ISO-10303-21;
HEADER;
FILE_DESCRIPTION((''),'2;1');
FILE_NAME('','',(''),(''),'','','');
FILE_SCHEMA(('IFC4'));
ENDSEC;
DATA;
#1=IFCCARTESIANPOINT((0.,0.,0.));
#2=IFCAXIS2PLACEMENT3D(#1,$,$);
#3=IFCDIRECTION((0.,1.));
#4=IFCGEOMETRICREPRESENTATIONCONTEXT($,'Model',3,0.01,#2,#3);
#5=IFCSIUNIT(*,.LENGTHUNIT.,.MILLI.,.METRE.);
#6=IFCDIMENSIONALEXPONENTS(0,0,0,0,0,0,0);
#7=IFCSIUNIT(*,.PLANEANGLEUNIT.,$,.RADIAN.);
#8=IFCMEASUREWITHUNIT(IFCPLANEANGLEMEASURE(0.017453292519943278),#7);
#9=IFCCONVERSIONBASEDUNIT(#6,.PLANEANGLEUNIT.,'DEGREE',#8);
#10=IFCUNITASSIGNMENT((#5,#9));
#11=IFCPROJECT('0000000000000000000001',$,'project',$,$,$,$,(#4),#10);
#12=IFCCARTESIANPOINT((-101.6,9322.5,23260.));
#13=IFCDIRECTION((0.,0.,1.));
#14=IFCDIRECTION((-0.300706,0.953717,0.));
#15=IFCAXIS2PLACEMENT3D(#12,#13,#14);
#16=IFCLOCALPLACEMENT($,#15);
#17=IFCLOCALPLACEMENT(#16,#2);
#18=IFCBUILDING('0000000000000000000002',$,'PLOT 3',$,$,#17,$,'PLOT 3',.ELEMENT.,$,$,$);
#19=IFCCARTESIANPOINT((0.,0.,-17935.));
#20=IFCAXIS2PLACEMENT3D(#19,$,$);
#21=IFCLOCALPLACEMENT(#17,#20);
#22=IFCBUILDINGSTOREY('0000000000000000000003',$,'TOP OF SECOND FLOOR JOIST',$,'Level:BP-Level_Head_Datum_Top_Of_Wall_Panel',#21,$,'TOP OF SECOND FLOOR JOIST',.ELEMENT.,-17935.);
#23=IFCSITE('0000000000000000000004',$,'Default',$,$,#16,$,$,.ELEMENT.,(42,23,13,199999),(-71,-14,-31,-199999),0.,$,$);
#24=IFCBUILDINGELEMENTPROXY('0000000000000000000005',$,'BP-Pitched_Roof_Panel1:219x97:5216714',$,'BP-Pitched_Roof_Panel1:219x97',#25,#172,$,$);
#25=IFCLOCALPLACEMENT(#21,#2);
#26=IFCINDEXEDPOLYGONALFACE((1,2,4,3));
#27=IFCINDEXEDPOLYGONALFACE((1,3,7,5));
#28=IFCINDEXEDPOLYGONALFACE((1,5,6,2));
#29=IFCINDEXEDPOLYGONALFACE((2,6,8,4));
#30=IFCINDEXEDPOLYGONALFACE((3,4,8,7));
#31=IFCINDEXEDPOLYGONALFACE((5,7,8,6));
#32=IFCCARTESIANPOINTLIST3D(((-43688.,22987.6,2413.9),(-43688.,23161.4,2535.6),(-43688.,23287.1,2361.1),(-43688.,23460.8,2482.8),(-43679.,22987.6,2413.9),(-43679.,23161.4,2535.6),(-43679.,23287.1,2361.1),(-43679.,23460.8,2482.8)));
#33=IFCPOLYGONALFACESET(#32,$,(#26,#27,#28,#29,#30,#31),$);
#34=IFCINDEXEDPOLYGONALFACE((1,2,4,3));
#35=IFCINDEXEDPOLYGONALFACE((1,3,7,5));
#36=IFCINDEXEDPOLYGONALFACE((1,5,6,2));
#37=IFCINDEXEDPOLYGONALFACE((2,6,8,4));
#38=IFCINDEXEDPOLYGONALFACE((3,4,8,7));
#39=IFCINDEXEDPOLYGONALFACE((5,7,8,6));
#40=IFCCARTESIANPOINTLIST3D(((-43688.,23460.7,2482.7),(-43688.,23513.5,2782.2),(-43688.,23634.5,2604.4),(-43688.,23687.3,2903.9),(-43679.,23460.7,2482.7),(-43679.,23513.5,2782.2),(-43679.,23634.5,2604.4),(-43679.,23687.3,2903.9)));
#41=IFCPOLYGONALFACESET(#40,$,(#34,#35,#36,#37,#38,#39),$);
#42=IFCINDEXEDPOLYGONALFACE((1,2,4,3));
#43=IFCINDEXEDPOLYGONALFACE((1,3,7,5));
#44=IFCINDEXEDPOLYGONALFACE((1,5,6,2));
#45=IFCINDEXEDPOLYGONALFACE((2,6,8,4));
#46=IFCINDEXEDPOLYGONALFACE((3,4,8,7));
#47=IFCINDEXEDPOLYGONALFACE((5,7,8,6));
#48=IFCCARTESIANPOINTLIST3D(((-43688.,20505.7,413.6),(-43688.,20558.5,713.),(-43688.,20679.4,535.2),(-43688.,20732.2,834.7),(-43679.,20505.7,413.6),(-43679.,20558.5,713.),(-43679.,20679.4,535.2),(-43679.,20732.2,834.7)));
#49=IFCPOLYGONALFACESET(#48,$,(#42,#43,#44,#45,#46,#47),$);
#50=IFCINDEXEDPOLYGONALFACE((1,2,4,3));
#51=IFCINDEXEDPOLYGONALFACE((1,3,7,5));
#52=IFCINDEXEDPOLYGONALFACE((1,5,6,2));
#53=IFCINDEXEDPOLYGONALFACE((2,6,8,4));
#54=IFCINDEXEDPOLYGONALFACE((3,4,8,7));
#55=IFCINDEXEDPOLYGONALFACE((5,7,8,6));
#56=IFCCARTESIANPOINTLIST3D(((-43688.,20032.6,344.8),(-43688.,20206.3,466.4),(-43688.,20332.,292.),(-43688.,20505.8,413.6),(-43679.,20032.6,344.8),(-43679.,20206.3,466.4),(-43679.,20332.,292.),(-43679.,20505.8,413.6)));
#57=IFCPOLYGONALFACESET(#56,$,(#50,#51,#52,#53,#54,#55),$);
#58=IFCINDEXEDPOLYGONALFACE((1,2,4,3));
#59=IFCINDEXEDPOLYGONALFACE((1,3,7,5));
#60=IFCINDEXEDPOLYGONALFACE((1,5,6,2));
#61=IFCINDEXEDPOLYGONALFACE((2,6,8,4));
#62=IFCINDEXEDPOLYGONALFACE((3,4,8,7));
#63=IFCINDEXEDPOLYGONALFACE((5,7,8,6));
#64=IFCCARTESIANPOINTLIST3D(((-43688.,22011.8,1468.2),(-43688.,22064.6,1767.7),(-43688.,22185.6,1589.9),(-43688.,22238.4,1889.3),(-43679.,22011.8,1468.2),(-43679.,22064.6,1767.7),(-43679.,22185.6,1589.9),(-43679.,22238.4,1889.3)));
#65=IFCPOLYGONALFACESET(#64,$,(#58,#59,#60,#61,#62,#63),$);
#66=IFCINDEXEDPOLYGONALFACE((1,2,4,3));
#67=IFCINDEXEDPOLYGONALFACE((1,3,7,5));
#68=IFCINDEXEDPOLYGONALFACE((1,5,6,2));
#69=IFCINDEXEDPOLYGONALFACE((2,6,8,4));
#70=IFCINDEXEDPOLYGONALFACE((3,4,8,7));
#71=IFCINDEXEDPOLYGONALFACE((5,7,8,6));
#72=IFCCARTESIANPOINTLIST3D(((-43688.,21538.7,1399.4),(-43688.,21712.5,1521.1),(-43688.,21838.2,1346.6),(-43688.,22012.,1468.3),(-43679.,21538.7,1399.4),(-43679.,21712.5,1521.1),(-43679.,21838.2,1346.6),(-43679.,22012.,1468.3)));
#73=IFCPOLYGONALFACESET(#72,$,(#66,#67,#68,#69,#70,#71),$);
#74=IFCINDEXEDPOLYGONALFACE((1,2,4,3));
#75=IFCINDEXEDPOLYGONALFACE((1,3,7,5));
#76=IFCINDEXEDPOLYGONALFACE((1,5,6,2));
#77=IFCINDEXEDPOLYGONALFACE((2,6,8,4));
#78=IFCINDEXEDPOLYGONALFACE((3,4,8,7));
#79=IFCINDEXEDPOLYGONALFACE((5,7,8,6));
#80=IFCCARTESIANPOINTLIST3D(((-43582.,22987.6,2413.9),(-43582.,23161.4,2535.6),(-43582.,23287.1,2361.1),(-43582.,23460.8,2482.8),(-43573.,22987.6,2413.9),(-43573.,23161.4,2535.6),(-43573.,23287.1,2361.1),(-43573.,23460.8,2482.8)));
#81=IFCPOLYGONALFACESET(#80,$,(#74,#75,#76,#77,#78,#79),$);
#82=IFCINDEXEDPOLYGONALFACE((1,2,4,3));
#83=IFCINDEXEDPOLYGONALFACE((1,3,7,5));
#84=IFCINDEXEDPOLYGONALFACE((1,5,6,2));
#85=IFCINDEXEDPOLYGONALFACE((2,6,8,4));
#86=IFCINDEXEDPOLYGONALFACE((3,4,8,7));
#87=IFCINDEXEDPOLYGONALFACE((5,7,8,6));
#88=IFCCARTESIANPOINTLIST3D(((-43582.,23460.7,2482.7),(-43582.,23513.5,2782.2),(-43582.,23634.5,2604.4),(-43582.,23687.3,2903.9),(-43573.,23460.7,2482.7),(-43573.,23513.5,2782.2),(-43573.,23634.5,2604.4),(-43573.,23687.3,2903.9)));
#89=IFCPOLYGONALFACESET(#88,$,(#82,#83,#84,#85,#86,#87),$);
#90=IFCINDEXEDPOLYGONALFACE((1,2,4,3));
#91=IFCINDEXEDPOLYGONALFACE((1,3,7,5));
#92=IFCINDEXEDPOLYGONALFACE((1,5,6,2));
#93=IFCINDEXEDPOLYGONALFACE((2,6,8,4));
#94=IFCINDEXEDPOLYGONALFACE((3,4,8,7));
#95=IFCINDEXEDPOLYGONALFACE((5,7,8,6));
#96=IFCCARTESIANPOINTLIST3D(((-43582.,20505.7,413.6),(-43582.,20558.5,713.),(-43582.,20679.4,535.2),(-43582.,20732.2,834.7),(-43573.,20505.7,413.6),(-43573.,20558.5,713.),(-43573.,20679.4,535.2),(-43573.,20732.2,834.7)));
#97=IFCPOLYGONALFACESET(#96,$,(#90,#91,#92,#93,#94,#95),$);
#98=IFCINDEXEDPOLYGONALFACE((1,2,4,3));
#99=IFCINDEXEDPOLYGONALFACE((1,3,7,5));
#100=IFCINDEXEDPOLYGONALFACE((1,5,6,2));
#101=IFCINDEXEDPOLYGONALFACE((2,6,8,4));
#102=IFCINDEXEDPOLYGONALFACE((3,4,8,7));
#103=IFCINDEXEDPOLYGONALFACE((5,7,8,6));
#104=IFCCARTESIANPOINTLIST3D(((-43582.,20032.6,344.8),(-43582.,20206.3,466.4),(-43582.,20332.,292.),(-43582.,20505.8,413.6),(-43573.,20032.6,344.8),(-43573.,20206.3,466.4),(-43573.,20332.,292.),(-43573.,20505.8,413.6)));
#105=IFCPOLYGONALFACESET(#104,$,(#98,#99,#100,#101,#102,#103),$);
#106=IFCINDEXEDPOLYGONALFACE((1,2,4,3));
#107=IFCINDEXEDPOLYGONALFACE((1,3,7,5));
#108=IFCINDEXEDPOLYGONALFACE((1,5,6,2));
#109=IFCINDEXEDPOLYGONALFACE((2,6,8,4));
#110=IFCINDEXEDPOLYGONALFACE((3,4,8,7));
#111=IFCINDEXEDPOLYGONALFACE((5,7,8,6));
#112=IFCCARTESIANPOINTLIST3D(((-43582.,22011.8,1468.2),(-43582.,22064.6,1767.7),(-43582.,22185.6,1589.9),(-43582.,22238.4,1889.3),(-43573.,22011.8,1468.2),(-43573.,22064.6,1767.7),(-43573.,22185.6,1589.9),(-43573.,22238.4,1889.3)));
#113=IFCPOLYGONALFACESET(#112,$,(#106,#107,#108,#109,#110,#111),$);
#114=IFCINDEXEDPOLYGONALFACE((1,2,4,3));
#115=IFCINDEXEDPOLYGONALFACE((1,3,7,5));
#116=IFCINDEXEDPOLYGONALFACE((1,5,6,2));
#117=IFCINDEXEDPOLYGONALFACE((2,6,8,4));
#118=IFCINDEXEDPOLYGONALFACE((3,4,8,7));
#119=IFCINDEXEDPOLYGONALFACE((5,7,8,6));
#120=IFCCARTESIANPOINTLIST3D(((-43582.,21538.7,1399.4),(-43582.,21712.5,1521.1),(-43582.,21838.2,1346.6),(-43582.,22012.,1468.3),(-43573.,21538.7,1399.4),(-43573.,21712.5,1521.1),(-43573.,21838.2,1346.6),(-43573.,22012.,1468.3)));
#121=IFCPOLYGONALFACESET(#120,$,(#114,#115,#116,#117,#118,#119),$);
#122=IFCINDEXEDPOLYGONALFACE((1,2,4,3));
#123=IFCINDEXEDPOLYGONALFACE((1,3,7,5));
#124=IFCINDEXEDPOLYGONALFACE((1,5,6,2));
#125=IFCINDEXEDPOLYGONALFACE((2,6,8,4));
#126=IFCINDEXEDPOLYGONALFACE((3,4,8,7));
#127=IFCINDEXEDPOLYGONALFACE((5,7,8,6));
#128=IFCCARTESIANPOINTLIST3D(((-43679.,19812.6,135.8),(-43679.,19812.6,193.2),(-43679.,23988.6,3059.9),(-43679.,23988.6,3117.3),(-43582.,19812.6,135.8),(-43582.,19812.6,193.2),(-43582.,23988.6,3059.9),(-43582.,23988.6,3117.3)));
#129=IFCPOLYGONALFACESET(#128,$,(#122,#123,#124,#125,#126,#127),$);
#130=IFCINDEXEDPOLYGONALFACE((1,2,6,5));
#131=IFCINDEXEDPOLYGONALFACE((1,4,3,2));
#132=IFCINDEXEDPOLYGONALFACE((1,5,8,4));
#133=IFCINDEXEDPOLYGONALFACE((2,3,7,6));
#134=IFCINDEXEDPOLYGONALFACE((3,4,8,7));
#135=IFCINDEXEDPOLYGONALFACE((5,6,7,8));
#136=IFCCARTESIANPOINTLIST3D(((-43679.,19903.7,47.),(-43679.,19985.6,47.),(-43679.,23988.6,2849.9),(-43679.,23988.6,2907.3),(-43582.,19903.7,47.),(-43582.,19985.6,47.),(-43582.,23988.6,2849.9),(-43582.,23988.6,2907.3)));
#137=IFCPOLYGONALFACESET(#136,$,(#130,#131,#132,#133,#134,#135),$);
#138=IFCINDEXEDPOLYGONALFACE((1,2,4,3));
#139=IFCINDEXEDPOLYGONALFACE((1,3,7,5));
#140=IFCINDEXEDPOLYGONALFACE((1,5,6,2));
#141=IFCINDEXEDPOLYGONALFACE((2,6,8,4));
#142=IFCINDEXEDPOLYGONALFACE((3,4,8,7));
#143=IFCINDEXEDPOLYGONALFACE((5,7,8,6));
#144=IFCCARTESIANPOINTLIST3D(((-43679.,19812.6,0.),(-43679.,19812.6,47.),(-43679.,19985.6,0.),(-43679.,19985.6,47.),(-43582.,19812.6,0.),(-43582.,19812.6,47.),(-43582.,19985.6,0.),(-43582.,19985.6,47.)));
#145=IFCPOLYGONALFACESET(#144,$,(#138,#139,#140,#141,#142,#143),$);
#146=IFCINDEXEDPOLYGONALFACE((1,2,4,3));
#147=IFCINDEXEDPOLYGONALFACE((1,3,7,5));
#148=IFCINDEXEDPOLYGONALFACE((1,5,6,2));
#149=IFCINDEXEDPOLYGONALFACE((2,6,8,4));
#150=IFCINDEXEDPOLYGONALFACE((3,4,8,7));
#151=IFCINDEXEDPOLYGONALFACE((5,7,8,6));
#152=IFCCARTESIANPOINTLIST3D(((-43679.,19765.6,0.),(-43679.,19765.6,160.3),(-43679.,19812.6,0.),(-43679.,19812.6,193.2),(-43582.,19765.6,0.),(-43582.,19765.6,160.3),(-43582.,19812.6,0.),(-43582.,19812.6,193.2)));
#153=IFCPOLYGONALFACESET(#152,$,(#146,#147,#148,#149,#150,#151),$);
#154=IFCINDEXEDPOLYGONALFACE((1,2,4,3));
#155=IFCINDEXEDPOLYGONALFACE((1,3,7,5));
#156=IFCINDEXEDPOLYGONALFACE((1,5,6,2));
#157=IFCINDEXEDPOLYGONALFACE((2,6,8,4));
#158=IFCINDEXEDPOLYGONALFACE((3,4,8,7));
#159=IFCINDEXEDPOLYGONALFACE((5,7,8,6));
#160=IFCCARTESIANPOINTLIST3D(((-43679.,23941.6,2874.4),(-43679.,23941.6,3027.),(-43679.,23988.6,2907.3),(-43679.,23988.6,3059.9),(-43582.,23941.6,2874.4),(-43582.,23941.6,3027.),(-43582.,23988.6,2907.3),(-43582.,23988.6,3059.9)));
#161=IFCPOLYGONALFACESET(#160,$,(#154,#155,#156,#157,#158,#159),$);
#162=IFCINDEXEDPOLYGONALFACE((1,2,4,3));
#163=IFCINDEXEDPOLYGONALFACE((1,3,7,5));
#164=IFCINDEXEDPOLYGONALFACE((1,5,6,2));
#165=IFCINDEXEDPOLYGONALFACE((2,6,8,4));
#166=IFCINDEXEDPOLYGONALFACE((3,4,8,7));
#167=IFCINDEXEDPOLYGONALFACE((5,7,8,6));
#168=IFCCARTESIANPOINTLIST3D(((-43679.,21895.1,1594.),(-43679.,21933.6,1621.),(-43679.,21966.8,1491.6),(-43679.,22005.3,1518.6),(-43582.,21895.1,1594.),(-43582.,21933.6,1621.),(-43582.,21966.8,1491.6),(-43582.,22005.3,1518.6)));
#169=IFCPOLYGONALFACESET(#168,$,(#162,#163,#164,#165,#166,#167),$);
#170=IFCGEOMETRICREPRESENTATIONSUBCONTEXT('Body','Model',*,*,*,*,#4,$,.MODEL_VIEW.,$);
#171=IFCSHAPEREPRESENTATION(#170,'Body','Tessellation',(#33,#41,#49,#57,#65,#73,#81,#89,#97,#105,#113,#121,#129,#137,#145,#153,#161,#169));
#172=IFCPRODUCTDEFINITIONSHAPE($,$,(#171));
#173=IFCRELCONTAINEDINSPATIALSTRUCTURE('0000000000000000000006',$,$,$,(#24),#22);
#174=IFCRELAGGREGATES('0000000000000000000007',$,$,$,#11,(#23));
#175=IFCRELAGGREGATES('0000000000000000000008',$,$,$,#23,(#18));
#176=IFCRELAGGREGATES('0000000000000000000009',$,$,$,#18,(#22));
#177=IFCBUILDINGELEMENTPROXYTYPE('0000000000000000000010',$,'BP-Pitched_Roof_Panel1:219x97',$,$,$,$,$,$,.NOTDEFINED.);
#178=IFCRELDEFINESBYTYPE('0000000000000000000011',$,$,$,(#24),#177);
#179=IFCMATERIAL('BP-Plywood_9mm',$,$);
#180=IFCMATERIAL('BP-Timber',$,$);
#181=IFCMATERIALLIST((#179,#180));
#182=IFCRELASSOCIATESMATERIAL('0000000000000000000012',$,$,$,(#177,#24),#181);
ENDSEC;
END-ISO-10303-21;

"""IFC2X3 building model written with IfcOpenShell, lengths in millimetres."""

from ifc_helpers import new_model, entity, si_unit, converted_unit, direction, frame, frame_2d, origin, origin_2d_with_axis, place, context, subcontext, project, spatial, polyline, rectangle, outline, extrude, source, transform, mapped, material, material_list, type_object, type_shapes, element, save


model = new_model("IFC2X3")

# Units and contexts
model_context = context("Model", 3, precision=0.01, world=origin(), true_north=direction((0.0, 1.0)))
body_context = subcontext(model_context, "Body", "Model", "MODEL_VIEW")
ifc_project = project(units=[si_unit("LENGTHUNIT", "METRE", prefix="MILLI"), converted_unit("PLANEANGLEUNIT", "DEGREE", entity("IfcPlaneAngleMeasure", 0.017453292519943278), si_unit("PLANEANGLEUNIT", "RADIAN"), dimensions=[0, 0, 0, 0, 0, 0, 0])], contexts=[model_context])

# Site, building, storey
site_placement = place(None, frame((-101.6, 9322.5, 23260.0), z_axis=(0.0, 0.0, 1.0), x_axis=(-0.300706, 0.953717, 0.0)))
site = spatial("IfcSite", under=ifc_project, at=site_placement, Name="Default", CompositionType="ELEMENT", RefLatitude=(42, 23, 13, 199999), RefLongitude=(-71, -14, -31, -199999), RefElevation=0.0)
building_placement = place(site_placement, origin())
building = spatial("IfcBuilding", under=site, at=building_placement, Name="PLOT 3", LongName="PLOT 3", CompositionType="ELEMENT")
storey_placement = place(building_placement, frame((0.0, 0.0, -17935.0)))
storey = spatial("IfcBuildingStorey", under=building, at=storey_placement, Name="TOP OF SECOND FLOOR JOIST", ObjectType="Level:BP-Level_Head_Datum_Top_Of_Wall_Panel", LongName="TOP OF SECOND FLOOR JOIST", CompositionType="ELEMENT", Elevation=-17935.0)

# Building element proxy
ifc_material_1 = material(Name="BP-Timber")
ifc_material_2 = material(Name="BP-Plywood_9mm")
ifc_material_list = material_list([ifc_material_2, ifc_material_1])
building_element_proxy_type_1 = type_object("IfcBuildingElementProxyType", Name="BP-Pitched_Roof_Panel1:219x97", PredefinedType="NOTDEFINED", material=ifc_material_list)
shared_shape_1 = source(origin(), body_context, "Body", "SweptSolid", [
    extrude(outline(polyline([(-77.0, -75.0), (227.0, -75.0), (77.0, 75.0), (-227.0, 75.0), (-77.0, -75.0)])), frame((36.3, 3947.0, 2448.4), z_axis=(0.0, 1.0, 0.0), x_axis=(-0.984808, 0.0, 0.173648)), (0.0, 0.0, 1.0), 9.0),
    extrude(outline(polyline([(1.4, -107.5), (213.6, -107.5), (-1.4, 107.5), (-213.6, 107.5), (1.4, -107.5)])), frame((386.1, 3947.0, 2693.3), z_axis=(0.0, 1.0, 0.0), x_axis=(-0.819152, 0.0, -0.573576)), (0.0, 0.0, 1.0), 9.0),
    extrude(outline(polyline([(1.4, -107.5), (213.6, -107.5), (-1.4, 107.5), (-213.6, 107.5), (1.4, -107.5)])), frame((-2569.0, 3947.0, 624.1), z_axis=(0.0, 1.0, 0.0), x_axis=(-0.819152, 0.0, -0.573576)), (0.0, 0.0, 1.0), 9.0),
    extrude(outline(polyline([(-77.0, -75.0), (227.0, -75.0), (77.0, 75.0), (-227.0, 75.0), (-77.0, -75.0)])), frame((-2918.8, 3947.0, 379.2), z_axis=(0.0, 1.0, 0.0), x_axis=(-0.984808, 0.0, 0.173648)), (0.0, 0.0, 1.0), 9.0),
    extrude(outline(polyline([(1.4, -107.5), (213.6, -107.5), (-1.4, 107.5), (-213.6, 107.5), (1.4, -107.5)])), frame((-1062.8, 3947.0, 1678.8), z_axis=(0.0, 1.0, 0.0), x_axis=(-0.819152, 0.0, -0.573576)), (0.0, 0.0, 1.0), 9.0),
    extrude(outline(polyline([(-77.0, -75.0), (227.0, -75.0), (77.0, 75.0), (-227.0, 75.0), (-77.0, -75.0)])), frame((-1412.6, 3947.0, 1433.9), z_axis=(0.0, 1.0, 0.0), x_axis=(-0.984808, 0.0, 0.173648)), (0.0, 0.0, 1.0), 9.0),
    extrude(outline(polyline([(-77.0, -75.0), (227.0, -75.0), (77.0, 75.0), (-227.0, 75.0), (-77.0, -75.0)])), frame((36.3, 3841.0, 2448.4), z_axis=(0.0, 1.0, 0.0), x_axis=(-0.984808, 0.0, 0.173648)), (0.0, 0.0, 1.0), 9.0),
    extrude(outline(polyline([(1.4, -107.5), (213.6, -107.5), (-1.4, 107.5), (-213.6, 107.5), (1.4, -107.5)])), frame((386.1, 3841.0, 2693.3), z_axis=(0.0, 1.0, 0.0), x_axis=(-0.819152, 0.0, -0.573576)), (0.0, 0.0, 1.0), 9.0),
    extrude(outline(polyline([(1.4, -107.5), (213.6, -107.5), (-1.4, 107.5), (-213.6, 107.5), (1.4, -107.5)])), frame((-2569.0, 3841.0, 624.1), z_axis=(0.0, 1.0, 0.0), x_axis=(-0.819152, 0.0, -0.573576)), (0.0, 0.0, 1.0), 9.0),
    extrude(outline(polyline([(-77.0, -75.0), (227.0, -75.0), (77.0, 75.0), (-227.0, 75.0), (-77.0, -75.0)])), frame((-2918.8, 3841.0, 379.2), z_axis=(0.0, 1.0, 0.0), x_axis=(-0.984808, 0.0, 0.173648)), (0.0, 0.0, 1.0), 9.0),
    extrude(outline(polyline([(1.4, -107.5), (213.6, -107.5), (-1.4, 107.5), (-213.6, 107.5), (1.4, -107.5)])), frame((-1062.8, 3841.0, 1678.8), z_axis=(0.0, 1.0, 0.0), x_axis=(-0.819152, 0.0, -0.573576)), (0.0, 0.0, 1.0), 9.0),
    extrude(outline(polyline([(-77.0, -75.0), (227.0, -75.0), (77.0, 75.0), (-227.0, 75.0), (-77.0, -75.0)])), frame((-1412.6, 3841.0, 1433.9), z_axis=(0.0, 1.0, 0.0), x_axis=(-0.984808, 0.0, 0.173648)), (0.0, 0.0, 1.0), 9.0),
    extrude(outline(polyline([(-1490.7, -2088.0), (-1433.3, -2088.0), (1490.7, 2088.0), (1433.3, 2088.0), (-1490.7, -2088.0)])), frame((-1287.3, 3850.0, 1626.6), z_axis=(0.0, 1.0, 0.0), x_axis=(0.0, 0.0, -1.0)), (0.0, 0.0, 1.0), 97.0),
    extrude(outline(polyline([(-1444.5, -2022.0), (-1387.1, -2022.0), (1415.8, 1981.0), (1415.8, 2063.0), (-1444.5, -2022.0)])), frame((-1221.3, 3850.0, 1462.8), z_axis=(0.0, 1.0, 0.0), x_axis=(0.0, 0.0, -1.0)), (0.0, 0.0, 1.0), 97.0),
    extrude(rectangle(XDim=97.0, YDim=173.0, at=origin_2d_with_axis()), frame((-3288.8, 3898.5, 0.0), z_axis=(0.0, 0.0, 1.0), x_axis=(0.0, 1.0, 0.0)), (0.0, 0.0, 1.0), 47.0),
    extrude(outline(polyline([(22.0, -72.4), (79.4, -72.4), (-31.4, 85.9), (-69.9, 58.9), (22.0, -72.4)])), frame((-3398.8, 3850.0, 88.4), z_axis=(0.0, 1.0, 0.0), x_axis=(0.819152, 0.0, 0.573576)), (0.0, 0.0, 1.0), 97.0),
    extrude(outline(polyline([(15.1, -62.5), (72.5, -62.5), (-15.1, 62.5), (-72.5, 62.5), (15.1, -62.5)])), frame((777.2, 3850.0, 2967.2), z_axis=(0.0, 1.0, 0.0), x_axis=(0.819152, 0.0, 0.573576)), (0.0, 0.0, 1.0), 97.0),
    extrude(rectangle(XDim=47.0, YDim=97.0, at=frame_2d((0.0, 0.0), x_axis=(0.0, 1.0))), frame((-1201.9, 3898.5, 1505.1), z_axis=(-0.573576, 0.0, 0.819152), x_axis=(0.0, 1.0, 0.0)), (0.0, 0.0, 1.0), 125.0),
])
type_shapes(building_element_proxy_type_1, [shared_shape_1])
for number, where, z_axis, x_axis, name in (
    (1, (-39732.0, 23187.9, 0.0), (0.0, 0.0, 1.0), (0.0, 1.0, 0.0), "BP-Pitched_Roof_Panel1:219x97:5216714"),
):
    element("IfcBuildingElementProxy", number, at=place(storey_placement, frame(where, z_axis=z_axis, x_axis=x_axis)), inside=storey, type_object=building_element_proxy_type_1, material=ifc_material_list, Name=name, ObjectType="BP-Pitched_Roof_Panel1:219x97", context=body_context, shape_type="MappedRepresentation", body=[
        mapped(shared_shape_1, transform((0.0, 0.0, 0.0), scale=1.0)),
    ])

save(model, "model.ifc")
